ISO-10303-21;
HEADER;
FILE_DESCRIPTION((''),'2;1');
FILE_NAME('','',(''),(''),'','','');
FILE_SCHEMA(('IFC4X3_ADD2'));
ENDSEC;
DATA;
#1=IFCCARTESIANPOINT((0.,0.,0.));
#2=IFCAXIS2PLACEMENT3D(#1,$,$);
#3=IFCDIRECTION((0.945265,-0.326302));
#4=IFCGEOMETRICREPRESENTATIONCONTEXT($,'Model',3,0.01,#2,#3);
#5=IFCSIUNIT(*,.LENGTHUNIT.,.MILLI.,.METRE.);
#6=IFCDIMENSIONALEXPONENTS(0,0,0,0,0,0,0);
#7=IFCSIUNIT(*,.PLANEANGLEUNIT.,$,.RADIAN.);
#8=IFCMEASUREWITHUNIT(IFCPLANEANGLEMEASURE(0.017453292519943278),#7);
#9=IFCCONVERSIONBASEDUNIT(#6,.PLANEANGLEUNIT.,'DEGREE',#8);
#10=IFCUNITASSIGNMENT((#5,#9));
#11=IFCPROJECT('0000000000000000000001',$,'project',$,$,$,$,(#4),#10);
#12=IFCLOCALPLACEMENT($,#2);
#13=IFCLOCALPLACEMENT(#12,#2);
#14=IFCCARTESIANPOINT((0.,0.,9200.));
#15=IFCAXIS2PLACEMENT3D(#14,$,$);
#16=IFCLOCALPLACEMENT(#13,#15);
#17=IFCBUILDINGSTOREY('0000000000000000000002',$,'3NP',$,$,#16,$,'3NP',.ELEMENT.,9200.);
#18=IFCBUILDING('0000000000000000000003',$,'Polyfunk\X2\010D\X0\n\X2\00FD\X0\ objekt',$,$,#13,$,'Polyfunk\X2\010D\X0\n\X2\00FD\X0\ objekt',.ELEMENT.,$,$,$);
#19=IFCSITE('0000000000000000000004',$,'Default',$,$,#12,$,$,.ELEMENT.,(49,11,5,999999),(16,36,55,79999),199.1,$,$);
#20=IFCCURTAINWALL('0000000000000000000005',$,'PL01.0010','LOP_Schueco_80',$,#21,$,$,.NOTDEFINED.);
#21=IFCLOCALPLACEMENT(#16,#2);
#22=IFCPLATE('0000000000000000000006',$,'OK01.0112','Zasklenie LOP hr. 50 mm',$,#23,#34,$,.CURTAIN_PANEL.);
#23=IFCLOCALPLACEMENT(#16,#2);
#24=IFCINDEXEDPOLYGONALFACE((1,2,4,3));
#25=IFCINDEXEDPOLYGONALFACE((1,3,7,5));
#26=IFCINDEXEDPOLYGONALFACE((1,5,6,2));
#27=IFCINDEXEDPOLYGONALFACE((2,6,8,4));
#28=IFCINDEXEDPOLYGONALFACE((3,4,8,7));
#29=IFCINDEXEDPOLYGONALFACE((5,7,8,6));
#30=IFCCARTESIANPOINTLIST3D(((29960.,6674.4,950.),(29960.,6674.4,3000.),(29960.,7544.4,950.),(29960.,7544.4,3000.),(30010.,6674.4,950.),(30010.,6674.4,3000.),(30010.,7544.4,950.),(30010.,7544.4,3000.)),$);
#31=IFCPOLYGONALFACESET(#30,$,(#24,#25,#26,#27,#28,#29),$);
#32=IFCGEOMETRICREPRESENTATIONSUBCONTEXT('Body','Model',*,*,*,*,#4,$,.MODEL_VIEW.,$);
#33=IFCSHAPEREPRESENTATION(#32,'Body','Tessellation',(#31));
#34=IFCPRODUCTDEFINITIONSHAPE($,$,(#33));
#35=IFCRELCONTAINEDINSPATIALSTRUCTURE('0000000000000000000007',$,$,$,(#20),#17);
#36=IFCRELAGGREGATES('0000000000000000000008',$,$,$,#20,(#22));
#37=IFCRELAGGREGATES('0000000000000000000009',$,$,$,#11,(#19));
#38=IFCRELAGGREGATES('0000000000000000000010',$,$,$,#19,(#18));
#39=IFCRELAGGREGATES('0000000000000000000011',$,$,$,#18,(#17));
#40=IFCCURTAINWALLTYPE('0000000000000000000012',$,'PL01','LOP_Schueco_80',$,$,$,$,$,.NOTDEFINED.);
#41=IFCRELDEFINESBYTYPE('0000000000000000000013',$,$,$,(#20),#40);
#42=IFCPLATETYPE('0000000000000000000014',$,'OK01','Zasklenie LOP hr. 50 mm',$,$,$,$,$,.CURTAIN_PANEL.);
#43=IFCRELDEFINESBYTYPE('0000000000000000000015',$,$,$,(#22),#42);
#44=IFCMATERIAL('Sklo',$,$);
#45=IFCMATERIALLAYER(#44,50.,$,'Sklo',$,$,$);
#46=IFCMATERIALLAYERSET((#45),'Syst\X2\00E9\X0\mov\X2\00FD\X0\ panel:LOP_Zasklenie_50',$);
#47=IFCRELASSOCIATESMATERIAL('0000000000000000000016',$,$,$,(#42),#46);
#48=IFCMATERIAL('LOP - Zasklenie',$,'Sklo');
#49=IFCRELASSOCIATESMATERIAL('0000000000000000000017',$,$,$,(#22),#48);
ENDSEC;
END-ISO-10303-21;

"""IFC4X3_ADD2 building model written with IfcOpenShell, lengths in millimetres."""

from ifc_helpers import new_model, entity, si_unit, converted_unit, direction, frame, origin, origin_2d_with_axis, place, context, subcontext, project, spatial, rectangle, extrude, source, transform, mapped, material, layer, layer_set, type_object, element, aggregate, save


model = new_model("IFC4X3_ADD2")

# Units and contexts
model_context = context("Model", 3, precision=0.01, world=origin(), true_north=direction((0.945265, -0.326302)))
body_context = subcontext(model_context, "Body", "Model", "MODEL_VIEW")
ifc_project = project(units=[si_unit("LENGTHUNIT", "METRE", prefix="MILLI"), converted_unit("PLANEANGLEUNIT", "DEGREE", entity("IfcPlaneAngleMeasure", 0.017453292519943278), si_unit("PLANEANGLEUNIT", "RADIAN"), dimensions=[0, 0, 0, 0, 0, 0, 0])], contexts=[model_context])

# Site, building, storey
site_placement = place(None, origin())
site = spatial("IfcSite", under=ifc_project, at=site_placement, Name="Default", CompositionType="ELEMENT", RefLatitude=(49, 11, 5, 999999), RefLongitude=(16, 36, 55, 79999), RefElevation=199.1)
building_placement = place(site_placement, origin())
building = spatial("IfcBuilding", under=site, at=building_placement, Name="Polyfunkčný objekt", LongName="Polyfunkčný objekt", CompositionType="ELEMENT")
storey_placement = place(building_placement, frame((0.0, 0.0, 9200.0)))
storey = spatial("IfcBuildingStorey", under=building, at=storey_placement, Name="3NP", LongName="3NP", CompositionType="ELEMENT", Elevation=9200.0)

# Shared definitions
curtain_wall_type = type_object("IfcCurtainWallType", Name="PL01", Description="LOP_Schueco_80", PredefinedType="NOTDEFINED")

# Curtain wall, plate
curtain_wall_1_placement = place(storey_placement, frame((0.0, 0.0, -9200.0)))
curtain_wall_1 = element("IfcCurtainWall", 1, at=curtain_wall_1_placement, inside=storey, type_object=curtain_wall_type, Name="PL01.0010", Description="LOP_Schueco_80", PredefinedType="NOTDEFINED")
ifc_material_1 = material(Name="LOP - Zasklenie", Category="Sklo")
ifc_material_2 = material(Name="Sklo")
ifc_layer_1 = layer(ifc_material_2, 50.0, Name="Sklo")
ifc_layer_set_1 = layer_set([ifc_layer_1], Name="Systémový panel:LOP_Zasklenie_50")
plate_type_1 = type_object("IfcPlateType", Name="OK01", Description="Zasklenie LOP hr. 50 mm", PredefinedType="CURTAIN_PANEL", material=ifc_layer_set_1)
shared_shape_1 = source(origin(), body_context, "Body", "SweptSolid", [
    extrude(rectangle(XDim=50.0, YDim=870.0, at=origin_2d_with_axis()), frame((0.0, -25.0, 0.0), z_axis=(0.0, 0.0, 1.0), x_axis=(0.0, 1.0, 0.0)), (0.0, 0.0, 1.0), 2050.0),
])
plate_1_placement = place(curtain_wall_1_placement, frame((30010.0, 7109.4, 10150.0), z_axis=(0.0, 0.0, 1.0), x_axis=(0.0, -1.0, 0.0)))
plate_1 = element("IfcPlate", 2, at=plate_1_placement, type_object=plate_type_1, material=ifc_material_1, Name="OK01.0112", Description="Zasklenie LOP hr. 50 mm", PredefinedType="CURTAIN_PANEL", context=body_context, shape_type="MappedRepresentation", body=[
    mapped(shared_shape_1, transform((0.0, 0.0, 0.0), scale=1.0)),
])
aggregate(curtain_wall_1, [plate_1])

save(model, "model.ifc")
